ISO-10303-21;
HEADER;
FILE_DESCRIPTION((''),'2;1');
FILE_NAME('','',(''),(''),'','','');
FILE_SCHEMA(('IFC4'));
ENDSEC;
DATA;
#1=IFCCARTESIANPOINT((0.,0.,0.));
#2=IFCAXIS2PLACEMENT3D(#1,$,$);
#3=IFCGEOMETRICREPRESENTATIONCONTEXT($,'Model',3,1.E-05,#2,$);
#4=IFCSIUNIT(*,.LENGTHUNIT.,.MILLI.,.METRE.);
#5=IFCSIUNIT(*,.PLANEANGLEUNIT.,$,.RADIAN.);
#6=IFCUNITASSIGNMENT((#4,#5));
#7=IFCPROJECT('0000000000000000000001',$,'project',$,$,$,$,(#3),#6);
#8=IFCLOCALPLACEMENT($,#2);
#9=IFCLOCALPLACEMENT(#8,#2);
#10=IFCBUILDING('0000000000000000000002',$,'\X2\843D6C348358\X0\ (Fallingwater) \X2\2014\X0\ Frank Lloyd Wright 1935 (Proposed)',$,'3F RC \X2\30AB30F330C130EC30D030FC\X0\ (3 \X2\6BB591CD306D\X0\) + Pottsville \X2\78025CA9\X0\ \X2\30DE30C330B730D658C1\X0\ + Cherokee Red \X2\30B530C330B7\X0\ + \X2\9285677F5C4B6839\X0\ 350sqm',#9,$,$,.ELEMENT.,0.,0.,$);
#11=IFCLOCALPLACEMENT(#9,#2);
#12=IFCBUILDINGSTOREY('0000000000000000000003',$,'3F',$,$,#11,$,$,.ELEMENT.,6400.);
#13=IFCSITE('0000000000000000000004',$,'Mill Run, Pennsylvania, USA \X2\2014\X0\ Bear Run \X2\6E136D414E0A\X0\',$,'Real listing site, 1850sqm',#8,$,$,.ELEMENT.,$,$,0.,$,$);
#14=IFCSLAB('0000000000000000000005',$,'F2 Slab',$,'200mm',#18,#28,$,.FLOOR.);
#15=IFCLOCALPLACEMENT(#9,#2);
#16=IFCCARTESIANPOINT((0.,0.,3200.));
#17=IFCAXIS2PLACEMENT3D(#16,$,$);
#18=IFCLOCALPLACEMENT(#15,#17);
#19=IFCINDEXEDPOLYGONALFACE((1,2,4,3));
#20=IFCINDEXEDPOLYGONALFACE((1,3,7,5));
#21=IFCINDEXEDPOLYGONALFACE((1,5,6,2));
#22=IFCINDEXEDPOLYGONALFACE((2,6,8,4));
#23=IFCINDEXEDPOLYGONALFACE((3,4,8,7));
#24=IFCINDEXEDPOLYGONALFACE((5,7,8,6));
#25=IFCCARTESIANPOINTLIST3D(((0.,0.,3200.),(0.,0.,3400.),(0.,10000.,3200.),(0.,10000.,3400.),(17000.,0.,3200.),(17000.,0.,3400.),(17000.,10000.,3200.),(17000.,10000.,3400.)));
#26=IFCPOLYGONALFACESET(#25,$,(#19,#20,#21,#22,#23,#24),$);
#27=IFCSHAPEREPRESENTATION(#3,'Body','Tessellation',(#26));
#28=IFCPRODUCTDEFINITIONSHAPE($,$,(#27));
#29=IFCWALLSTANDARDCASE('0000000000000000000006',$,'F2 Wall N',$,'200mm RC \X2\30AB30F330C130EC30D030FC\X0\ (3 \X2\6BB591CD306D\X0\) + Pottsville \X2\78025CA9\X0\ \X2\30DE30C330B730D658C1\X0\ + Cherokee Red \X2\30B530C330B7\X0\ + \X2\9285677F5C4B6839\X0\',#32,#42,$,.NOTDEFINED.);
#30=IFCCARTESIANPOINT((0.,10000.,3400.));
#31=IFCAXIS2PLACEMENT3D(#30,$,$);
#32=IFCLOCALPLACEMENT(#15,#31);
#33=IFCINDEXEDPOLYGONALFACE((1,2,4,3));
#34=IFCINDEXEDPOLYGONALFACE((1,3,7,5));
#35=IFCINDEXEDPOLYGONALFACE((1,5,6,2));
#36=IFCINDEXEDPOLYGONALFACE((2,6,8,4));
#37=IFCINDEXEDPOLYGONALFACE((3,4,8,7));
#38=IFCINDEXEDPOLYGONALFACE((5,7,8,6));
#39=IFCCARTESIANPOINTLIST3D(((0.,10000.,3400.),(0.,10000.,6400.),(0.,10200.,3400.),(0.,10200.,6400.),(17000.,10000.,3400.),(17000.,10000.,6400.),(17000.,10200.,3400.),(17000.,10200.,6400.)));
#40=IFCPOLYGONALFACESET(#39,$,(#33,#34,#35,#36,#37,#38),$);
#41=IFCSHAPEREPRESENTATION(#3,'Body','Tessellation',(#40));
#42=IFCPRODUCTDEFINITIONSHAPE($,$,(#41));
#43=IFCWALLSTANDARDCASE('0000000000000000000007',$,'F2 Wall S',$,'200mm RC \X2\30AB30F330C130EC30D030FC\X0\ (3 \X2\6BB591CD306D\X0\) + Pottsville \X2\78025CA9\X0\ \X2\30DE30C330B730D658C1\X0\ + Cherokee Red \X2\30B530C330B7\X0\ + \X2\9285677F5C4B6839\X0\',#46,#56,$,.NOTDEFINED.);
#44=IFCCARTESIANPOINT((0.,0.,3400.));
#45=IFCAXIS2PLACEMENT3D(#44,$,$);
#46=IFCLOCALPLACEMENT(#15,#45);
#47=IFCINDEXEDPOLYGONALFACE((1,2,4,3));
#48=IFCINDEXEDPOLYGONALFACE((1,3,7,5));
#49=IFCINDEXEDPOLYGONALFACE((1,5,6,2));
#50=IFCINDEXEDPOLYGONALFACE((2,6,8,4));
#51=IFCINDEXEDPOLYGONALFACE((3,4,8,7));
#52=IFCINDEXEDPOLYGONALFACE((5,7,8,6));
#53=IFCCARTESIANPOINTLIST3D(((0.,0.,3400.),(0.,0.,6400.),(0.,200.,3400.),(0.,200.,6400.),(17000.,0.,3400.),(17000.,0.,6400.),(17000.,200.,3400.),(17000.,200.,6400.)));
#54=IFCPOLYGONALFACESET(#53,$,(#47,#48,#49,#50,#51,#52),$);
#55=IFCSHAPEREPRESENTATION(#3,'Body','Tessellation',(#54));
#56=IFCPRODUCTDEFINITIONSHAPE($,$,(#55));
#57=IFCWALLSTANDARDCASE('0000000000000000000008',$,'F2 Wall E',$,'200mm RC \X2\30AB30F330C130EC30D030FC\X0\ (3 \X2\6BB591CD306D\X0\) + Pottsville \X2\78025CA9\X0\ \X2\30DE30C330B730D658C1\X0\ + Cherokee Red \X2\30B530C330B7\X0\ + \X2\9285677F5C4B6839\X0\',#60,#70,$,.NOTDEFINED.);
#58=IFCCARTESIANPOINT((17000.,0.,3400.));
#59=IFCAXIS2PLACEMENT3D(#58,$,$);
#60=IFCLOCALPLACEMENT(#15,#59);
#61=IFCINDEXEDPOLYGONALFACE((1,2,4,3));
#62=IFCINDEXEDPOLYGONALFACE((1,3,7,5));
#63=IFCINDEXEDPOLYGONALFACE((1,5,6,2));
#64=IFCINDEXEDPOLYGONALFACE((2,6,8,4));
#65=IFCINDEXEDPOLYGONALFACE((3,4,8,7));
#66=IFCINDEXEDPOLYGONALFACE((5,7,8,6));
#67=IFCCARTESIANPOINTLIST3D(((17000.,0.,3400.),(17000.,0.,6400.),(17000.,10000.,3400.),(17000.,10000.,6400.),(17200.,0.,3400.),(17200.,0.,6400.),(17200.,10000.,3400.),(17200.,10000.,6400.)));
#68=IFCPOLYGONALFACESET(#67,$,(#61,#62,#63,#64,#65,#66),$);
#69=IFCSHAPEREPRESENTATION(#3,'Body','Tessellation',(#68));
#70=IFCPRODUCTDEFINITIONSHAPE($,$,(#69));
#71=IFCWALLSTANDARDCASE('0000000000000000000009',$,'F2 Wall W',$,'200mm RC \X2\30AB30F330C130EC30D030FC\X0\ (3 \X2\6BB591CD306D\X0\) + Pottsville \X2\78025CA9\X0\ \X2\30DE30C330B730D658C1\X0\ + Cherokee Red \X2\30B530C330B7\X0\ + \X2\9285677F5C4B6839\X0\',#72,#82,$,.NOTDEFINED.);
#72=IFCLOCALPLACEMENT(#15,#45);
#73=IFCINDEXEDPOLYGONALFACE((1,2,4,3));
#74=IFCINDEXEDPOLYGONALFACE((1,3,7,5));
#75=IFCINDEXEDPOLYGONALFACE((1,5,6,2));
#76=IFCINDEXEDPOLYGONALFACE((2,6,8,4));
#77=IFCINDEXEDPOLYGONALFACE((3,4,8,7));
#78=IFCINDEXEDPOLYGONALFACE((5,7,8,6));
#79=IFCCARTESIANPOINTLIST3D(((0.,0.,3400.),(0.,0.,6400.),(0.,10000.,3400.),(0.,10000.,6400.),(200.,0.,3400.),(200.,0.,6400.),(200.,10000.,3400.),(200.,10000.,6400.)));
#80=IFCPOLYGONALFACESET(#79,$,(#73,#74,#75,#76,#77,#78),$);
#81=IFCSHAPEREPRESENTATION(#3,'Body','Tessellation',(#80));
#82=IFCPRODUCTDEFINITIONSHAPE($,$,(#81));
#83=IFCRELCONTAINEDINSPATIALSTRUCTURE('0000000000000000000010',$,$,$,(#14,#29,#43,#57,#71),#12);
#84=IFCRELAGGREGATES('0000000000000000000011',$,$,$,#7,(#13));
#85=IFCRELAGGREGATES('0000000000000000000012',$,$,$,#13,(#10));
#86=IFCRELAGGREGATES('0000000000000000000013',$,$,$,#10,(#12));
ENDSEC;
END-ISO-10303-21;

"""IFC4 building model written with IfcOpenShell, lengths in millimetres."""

from ifc_helpers import new_model, si_unit, frame, frame_2d, origin, place, context, project, spatial, rectangle, extrude, element, save


model = new_model("IFC4")

# Units and contexts
model_context = context("Model", 3, precision=1e-05, world=origin())
ifc_project = project(units=[si_unit("LENGTHUNIT", "METRE", prefix="MILLI"), si_unit("PLANEANGLEUNIT", "RADIAN")], contexts=[model_context])

# Site, building, storey
site_placement = place(None, origin())
site = spatial("IfcSite", under=ifc_project, at=site_placement, Name="Mill Run, Pennsylvania, USA — Bear Run 渓流上", ObjectType="Real listing site, 1850sqm", CompositionType="ELEMENT", RefElevation=0.0)
building_placement = place(site_placement, origin())
building = spatial("IfcBuilding", under=site, at=building_placement, Name="落水荘 (Fallingwater) — Frank Lloyd Wright 1935 (Proposed)", ObjectType="3F RC カンチレバー (3 段重ね) + Pottsville 砂岩 マッシブ壁 + Cherokee Red サッシ + 銅板屋根 350sqm", CompositionType="ELEMENT", ElevationOfRefHeight=0.0, ElevationOfTerrain=0.0)
storey_placement = place(building_placement, origin())
storey = spatial("IfcBuildingStorey", under=building, at=storey_placement, Name="3F", CompositionType="ELEMENT", Elevation=6400.0)

# Slab
placement = place(building_placement, origin())
slab_placement = place(placement, frame((0.0, 0.0, 3200.0)))
element("IfcSlab", 1, at=slab_placement, inside=storey, Name="F2 Slab", ObjectType="200mm", PredefinedType="FLOOR", context=model_context, shape_type="SweptSolid", body=[
    extrude(rectangle(XDim=17000.0, YDim=10000.0, at=frame_2d((8500.0, 5000.0))), frame((0.0, 0.0, 3200.0)), (0.0, 0.0, 1.0), 200.0),
])

# Walls
wall_1_placement = place(placement, frame((0.0, 10000.0, 3400.0)))
element("IfcWallStandardCase", 2, at=wall_1_placement, inside=storey, Name="F2 Wall N", ObjectType="200mm RC カンチレバー (3 段重ね) + Pottsville 砂岩 マッシブ壁 + Cherokee Red サッシ + 銅板屋根", PredefinedType="NOTDEFINED", context=model_context, shape_type="SweptSolid", body=[
    extrude(rectangle(XDim=17000.0, YDim=200.0, at=frame_2d((8500.0, 100.0))), frame((0.0, 10000.0, 3400.0)), (0.0, 0.0, 1.0), 3000.0),
])
wall_2_placement = place(placement, frame((0.0, 0.0, 3400.0)))
element("IfcWallStandardCase", 3, at=wall_2_placement, inside=storey, Name="F2 Wall S", ObjectType="200mm RC カンチレバー (3 段重ね) + Pottsville 砂岩 マッシブ壁 + Cherokee Red サッシ + 銅板屋根", PredefinedType="NOTDEFINED", context=model_context, shape_type="SweptSolid", body=[
    extrude(rectangle(XDim=17000.0, YDim=200.0, at=frame_2d((8500.0, 100.0))), frame((0.0, 0.0, 3400.0)), (0.0, 0.0, 1.0), 3000.0),
])
wall_3_placement = place(placement, frame((17000.0, 0.0, 3400.0)))
element("IfcWallStandardCase", 4, at=wall_3_placement, inside=storey, Name="F2 Wall E", ObjectType="200mm RC カンチレバー (3 段重ね) + Pottsville 砂岩 マッシブ壁 + Cherokee Red サッシ + 銅板屋根", PredefinedType="NOTDEFINED", context=model_context, shape_type="SweptSolid", body=[
    extrude(rectangle(XDim=200.0, YDim=10000.0, at=frame_2d((100.0, 5000.0))), frame((17000.0, 0.0, 3400.0)), (0.0, 0.0, 1.0), 3000.0),
])
wall_4_placement = place(placement, frame((0.0, 0.0, 3400.0)))
element("IfcWallStandardCase", 5, at=wall_4_placement, inside=storey, Name="F2 Wall W", ObjectType="200mm RC カンチレバー (3 段重ね) + Pottsville 砂岩 マッシブ壁 + Cherokee Red サッシ + 銅板屋根", PredefinedType="NOTDEFINED", context=model_context, shape_type="SweptSolid", body=[
    extrude(rectangle(XDim=200.0, YDim=10000.0, at=frame_2d((100.0, 5000.0))), frame((0.0, 0.0, 3400.0)), (0.0, 0.0, 1.0), 3000.0),
])

save(model, "model.ifc")
